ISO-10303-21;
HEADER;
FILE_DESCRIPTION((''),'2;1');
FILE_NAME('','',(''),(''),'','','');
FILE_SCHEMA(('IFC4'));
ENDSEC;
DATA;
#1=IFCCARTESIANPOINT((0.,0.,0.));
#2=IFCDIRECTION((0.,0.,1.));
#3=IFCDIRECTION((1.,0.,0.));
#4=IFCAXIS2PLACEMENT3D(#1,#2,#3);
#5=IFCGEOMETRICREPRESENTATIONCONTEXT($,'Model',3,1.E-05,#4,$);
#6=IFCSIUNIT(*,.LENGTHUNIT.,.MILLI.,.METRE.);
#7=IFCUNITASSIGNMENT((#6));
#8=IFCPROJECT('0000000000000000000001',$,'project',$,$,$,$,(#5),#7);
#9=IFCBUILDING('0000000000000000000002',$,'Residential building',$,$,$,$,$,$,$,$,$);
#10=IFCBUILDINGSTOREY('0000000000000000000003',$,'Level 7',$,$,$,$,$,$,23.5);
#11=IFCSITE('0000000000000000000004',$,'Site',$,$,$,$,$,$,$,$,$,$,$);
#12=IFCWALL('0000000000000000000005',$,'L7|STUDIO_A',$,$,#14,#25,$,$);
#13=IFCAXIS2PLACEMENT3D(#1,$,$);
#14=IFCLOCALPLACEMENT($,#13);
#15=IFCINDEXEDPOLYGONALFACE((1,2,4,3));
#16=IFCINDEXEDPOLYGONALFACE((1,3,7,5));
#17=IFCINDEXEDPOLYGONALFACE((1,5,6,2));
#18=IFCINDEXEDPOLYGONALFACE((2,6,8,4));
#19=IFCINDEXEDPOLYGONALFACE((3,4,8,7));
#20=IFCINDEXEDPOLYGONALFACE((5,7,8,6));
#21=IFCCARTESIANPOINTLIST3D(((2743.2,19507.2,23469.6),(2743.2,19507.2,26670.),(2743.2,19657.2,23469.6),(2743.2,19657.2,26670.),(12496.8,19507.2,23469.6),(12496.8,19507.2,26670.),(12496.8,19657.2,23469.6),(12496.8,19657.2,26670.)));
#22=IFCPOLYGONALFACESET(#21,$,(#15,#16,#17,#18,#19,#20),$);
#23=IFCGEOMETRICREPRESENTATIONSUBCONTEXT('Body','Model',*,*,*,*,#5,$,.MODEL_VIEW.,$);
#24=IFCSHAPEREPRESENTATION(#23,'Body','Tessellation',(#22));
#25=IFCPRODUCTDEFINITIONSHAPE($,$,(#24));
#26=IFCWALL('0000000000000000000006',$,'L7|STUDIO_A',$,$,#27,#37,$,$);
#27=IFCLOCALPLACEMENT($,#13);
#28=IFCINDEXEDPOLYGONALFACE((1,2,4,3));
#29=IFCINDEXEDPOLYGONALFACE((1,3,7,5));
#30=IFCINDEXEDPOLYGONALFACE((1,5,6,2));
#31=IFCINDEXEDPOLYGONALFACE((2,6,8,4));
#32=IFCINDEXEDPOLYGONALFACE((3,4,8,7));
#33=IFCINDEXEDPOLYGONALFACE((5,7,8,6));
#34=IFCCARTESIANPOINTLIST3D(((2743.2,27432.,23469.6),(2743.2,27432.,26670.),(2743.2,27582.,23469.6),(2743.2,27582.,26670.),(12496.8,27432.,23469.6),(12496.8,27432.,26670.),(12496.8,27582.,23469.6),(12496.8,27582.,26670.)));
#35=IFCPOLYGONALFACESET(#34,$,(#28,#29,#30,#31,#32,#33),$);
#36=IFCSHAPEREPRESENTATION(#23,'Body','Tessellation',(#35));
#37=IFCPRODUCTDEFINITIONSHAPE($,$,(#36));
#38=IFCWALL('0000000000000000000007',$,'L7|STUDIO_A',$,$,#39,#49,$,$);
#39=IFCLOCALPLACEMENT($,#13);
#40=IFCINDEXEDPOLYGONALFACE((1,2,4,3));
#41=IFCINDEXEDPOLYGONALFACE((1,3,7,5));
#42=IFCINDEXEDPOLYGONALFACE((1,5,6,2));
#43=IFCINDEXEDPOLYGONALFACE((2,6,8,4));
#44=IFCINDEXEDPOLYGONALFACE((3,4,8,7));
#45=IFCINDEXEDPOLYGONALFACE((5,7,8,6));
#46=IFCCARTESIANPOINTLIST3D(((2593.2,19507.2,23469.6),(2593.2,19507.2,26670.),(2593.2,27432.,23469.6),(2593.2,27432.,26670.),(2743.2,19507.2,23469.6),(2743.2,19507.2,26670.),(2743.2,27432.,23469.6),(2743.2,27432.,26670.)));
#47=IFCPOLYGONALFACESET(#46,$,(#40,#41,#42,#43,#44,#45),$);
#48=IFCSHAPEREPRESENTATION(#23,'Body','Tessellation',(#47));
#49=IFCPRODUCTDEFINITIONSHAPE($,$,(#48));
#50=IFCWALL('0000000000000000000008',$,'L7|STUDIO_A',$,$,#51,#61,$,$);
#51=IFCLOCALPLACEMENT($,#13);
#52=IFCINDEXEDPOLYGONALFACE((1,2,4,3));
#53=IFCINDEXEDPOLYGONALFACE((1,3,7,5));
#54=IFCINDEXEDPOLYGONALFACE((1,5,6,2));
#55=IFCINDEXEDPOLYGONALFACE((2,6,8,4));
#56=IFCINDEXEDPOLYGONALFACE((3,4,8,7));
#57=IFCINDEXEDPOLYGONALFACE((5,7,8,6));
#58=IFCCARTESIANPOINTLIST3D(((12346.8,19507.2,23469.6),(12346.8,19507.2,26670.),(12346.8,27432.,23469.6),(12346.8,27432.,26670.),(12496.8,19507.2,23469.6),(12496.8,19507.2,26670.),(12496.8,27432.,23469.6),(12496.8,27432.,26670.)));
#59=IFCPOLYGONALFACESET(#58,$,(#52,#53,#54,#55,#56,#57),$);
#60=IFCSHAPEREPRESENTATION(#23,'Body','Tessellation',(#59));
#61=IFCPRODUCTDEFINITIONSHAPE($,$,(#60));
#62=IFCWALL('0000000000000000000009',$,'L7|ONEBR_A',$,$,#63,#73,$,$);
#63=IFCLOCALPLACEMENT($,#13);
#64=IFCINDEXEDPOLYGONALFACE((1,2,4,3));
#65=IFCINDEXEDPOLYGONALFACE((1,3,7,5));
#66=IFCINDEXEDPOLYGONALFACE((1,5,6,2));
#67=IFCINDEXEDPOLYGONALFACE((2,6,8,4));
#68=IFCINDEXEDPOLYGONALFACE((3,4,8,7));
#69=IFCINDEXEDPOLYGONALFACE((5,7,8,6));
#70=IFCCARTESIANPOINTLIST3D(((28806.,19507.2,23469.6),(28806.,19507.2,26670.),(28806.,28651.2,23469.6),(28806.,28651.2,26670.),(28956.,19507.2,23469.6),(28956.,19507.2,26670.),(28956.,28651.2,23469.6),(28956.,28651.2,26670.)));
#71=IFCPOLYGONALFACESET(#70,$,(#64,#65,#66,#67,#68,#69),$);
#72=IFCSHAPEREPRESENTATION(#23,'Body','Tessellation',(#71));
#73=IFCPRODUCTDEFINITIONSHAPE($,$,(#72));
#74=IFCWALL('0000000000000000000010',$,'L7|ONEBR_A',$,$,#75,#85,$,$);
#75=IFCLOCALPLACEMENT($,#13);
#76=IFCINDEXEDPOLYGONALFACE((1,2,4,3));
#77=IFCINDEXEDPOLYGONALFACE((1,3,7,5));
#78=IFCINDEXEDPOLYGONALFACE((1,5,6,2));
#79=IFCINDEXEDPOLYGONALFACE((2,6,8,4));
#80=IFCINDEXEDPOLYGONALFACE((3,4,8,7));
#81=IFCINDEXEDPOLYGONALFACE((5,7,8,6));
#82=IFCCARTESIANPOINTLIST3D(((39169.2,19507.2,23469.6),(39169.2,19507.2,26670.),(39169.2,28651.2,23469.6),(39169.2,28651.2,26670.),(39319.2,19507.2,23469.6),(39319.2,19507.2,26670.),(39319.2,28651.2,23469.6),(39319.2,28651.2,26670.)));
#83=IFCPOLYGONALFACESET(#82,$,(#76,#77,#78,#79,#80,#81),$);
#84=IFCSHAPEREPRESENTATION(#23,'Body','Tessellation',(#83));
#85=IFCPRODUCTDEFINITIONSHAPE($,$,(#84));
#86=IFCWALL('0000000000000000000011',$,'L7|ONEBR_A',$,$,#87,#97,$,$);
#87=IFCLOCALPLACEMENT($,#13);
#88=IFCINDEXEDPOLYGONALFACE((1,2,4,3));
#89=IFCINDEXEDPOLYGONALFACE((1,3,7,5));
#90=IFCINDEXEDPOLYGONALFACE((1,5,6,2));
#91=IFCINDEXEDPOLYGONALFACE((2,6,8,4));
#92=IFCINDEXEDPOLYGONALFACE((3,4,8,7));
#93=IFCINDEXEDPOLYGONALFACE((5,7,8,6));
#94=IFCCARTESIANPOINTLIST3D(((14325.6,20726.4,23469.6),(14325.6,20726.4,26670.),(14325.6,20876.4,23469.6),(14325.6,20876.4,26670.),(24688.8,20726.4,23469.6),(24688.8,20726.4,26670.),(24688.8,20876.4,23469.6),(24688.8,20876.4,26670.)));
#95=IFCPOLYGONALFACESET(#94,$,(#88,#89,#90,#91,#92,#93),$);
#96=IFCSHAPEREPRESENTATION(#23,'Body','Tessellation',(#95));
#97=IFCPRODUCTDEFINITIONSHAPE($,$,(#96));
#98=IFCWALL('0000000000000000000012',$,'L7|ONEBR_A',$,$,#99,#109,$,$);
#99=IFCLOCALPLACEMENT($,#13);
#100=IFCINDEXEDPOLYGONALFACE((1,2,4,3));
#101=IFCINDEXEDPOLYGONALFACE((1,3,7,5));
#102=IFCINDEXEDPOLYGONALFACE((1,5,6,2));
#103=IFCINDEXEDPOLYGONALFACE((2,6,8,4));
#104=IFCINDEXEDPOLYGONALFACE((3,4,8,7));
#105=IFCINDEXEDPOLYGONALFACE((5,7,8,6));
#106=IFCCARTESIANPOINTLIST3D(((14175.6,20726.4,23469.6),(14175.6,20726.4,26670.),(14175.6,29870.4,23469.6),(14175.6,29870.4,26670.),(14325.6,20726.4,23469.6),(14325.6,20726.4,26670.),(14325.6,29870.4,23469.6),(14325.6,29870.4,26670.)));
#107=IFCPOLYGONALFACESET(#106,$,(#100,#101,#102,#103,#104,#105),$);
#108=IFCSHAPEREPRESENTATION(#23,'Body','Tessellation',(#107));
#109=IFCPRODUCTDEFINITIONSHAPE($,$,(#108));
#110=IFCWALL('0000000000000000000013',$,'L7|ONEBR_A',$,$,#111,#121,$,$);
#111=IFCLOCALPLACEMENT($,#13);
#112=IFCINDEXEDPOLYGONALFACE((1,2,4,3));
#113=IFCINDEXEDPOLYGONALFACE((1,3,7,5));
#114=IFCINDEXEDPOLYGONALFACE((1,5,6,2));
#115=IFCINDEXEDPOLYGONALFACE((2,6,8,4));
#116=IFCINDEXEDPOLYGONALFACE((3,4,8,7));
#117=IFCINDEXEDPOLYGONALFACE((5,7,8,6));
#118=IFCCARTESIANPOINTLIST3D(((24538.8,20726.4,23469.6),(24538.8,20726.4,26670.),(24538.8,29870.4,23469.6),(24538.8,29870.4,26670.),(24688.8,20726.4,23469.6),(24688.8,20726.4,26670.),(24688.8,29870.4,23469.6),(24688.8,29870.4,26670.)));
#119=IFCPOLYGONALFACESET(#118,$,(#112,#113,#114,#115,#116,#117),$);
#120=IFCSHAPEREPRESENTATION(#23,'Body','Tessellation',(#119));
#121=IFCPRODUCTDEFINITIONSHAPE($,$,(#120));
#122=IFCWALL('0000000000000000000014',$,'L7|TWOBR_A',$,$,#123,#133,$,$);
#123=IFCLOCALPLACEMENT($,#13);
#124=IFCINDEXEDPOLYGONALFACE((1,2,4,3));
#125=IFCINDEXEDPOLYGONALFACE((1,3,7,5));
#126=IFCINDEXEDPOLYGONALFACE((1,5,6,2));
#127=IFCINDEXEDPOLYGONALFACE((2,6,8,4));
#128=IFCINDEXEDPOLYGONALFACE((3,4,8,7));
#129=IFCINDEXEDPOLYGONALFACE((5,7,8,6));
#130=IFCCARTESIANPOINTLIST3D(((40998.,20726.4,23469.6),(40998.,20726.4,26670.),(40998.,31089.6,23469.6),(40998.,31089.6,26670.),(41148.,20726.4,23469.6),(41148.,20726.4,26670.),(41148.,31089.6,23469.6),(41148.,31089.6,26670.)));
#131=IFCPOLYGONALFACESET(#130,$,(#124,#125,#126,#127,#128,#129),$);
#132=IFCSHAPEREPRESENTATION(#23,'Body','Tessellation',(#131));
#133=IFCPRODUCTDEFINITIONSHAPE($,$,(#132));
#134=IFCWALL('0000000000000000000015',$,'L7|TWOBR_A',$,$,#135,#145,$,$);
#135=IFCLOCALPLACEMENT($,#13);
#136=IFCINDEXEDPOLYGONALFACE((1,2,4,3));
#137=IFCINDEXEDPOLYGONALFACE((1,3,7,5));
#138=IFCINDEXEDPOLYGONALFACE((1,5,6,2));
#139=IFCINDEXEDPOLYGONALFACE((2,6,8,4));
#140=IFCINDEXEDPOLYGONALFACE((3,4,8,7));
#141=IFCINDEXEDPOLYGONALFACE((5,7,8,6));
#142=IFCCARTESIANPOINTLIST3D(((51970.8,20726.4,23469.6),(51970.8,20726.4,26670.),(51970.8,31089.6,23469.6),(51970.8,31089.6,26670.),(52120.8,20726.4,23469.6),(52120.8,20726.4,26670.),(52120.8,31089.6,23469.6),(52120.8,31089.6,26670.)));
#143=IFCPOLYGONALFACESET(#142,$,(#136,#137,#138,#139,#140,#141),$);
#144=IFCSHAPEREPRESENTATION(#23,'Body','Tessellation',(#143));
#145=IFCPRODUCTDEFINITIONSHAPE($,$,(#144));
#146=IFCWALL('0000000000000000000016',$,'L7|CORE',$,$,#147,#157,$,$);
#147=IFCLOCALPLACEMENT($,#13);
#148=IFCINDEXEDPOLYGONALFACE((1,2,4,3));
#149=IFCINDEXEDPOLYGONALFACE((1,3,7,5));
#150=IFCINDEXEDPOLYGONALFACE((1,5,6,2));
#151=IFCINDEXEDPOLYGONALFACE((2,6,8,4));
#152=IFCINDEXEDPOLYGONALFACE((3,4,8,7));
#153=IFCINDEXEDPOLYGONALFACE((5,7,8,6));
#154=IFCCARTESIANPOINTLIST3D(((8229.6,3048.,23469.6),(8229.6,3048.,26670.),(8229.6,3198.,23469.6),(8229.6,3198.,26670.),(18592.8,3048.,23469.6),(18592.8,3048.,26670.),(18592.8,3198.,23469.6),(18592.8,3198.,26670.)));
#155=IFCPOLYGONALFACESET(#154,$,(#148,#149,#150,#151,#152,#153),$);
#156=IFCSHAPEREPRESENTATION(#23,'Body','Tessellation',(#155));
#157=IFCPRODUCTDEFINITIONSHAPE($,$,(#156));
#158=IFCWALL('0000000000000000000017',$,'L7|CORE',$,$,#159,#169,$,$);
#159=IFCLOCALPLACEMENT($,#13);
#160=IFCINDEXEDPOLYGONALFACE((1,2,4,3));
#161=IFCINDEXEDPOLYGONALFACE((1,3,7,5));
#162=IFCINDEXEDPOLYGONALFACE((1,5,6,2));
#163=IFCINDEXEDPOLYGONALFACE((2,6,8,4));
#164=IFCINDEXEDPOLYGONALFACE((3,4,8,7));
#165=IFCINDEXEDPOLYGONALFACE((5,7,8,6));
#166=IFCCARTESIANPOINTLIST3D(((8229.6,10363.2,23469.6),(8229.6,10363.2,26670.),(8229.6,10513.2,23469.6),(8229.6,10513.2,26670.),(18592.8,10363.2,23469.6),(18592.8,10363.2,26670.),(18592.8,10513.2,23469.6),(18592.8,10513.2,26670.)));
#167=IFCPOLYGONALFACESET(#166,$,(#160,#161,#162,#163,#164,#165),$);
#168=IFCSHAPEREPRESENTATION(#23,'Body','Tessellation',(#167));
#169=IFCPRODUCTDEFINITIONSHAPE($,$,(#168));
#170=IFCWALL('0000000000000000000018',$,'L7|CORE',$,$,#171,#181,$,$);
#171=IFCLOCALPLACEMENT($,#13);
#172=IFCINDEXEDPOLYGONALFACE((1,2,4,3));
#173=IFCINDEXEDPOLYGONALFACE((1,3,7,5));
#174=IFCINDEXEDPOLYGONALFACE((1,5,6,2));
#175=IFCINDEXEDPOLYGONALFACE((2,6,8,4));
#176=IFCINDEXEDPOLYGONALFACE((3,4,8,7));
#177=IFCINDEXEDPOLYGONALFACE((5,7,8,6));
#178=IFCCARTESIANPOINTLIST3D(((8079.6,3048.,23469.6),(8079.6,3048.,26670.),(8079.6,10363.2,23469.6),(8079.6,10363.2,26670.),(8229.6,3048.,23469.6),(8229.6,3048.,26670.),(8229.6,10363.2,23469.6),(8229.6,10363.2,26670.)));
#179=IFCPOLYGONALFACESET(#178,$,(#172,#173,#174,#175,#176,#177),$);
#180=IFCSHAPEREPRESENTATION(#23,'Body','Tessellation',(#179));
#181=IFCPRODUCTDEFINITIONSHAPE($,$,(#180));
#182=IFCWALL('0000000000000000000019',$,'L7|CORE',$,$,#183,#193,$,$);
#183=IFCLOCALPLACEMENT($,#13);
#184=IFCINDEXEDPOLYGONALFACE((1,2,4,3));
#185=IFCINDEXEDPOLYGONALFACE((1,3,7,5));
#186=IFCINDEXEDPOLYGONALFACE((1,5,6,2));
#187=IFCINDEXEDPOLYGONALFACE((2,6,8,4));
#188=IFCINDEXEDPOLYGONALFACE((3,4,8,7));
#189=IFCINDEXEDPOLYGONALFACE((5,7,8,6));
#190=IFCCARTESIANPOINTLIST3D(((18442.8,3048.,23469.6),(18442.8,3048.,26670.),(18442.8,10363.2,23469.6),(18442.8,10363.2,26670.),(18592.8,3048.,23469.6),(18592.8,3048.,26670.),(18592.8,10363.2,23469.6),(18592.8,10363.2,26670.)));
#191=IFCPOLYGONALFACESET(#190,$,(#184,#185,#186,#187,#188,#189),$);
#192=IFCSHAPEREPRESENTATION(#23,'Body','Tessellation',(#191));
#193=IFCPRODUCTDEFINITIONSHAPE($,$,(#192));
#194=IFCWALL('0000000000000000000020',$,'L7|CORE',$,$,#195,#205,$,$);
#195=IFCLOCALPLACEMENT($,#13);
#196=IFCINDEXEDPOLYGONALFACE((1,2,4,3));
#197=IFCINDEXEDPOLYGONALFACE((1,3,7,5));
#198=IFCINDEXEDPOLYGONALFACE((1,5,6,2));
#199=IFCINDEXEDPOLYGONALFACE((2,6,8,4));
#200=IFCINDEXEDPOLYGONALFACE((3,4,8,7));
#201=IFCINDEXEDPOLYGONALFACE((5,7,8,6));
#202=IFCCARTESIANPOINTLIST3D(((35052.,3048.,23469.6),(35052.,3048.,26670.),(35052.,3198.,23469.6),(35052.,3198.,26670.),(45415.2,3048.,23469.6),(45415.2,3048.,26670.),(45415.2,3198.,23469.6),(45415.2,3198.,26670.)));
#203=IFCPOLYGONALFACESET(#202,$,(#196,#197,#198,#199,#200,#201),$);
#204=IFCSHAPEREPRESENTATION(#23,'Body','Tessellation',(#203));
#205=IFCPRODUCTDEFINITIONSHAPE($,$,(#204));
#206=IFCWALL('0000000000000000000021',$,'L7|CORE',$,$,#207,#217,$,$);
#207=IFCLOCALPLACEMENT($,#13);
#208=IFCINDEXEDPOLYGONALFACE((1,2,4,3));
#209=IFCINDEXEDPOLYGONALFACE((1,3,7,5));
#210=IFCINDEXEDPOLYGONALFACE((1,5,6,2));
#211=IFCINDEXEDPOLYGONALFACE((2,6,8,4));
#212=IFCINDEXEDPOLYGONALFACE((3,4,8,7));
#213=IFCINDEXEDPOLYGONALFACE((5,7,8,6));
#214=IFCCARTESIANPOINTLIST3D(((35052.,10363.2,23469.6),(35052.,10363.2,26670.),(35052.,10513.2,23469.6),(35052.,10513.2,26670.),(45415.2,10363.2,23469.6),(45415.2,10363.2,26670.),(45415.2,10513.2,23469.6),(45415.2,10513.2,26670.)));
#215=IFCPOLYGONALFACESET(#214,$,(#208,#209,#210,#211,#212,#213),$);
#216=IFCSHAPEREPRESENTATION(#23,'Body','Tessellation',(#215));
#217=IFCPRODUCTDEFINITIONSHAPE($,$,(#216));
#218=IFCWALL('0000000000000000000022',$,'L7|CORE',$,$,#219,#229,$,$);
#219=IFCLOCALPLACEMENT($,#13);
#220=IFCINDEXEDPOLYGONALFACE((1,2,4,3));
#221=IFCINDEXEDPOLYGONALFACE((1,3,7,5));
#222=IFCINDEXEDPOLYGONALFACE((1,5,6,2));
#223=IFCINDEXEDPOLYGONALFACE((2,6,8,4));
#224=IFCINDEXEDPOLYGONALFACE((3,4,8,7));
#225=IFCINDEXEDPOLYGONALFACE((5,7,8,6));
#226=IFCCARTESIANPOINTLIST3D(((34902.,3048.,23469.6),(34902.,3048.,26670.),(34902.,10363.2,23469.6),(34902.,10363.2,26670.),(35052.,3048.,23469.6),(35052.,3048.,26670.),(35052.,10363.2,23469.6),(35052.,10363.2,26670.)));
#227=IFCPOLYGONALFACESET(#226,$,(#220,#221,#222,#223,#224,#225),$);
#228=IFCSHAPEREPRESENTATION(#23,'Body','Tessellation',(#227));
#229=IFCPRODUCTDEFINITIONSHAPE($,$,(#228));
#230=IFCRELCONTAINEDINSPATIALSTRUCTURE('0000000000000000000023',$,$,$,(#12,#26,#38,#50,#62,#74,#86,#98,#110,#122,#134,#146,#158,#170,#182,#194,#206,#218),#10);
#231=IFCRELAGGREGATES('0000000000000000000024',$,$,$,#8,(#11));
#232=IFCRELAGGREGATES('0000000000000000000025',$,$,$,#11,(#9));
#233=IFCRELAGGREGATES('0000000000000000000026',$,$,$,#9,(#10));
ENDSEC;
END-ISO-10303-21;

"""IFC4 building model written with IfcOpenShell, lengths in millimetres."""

from ifc_helpers import new_model, si_unit, frame, origin_with_axes, place, context, subcontext, project, spatial, indexed_curve, outline, extrude, element, save


model = new_model("IFC4")

# Units and contexts
model_context = context("Model", 3, precision=1e-05, world=origin_with_axes())
body_context = subcontext(model_context, "Body", "Model", "MODEL_VIEW")
ifc_project = project(units=[si_unit("LENGTHUNIT", "METRE", prefix="MILLI")], contexts=[model_context])

# Site, building, storey
site = spatial("IfcSite", under=ifc_project, Name="Site")
building = spatial("IfcBuilding", under=site, Name="Residential building")
storey = spatial("IfcBuildingStorey", under=building, Name="Level 7", Elevation=23.5)

# Walls
for number, where, z_axis, x_axis, name in (
    (1, (2743.2, 19507.2, 23469.6), (0.0, 0.0, 1.0), (1.0, 0.0, 0.0), "L7|STUDIO_A"),
    (2, (2743.2, 27432.0, 23469.6), (0.0, 0.0, 1.0), (1.0, 0.0, 0.0), "L7|STUDIO_A"),
):
    element("IfcWall", number, at=place(None, frame(where, z_axis=z_axis, x_axis=x_axis)), inside=storey, Name=name, context=body_context, shape_type="SweptSolid", body=[
        extrude(outline(indexed_curve([(0.0, 0.0), (0.0, 150.0), (9753.6, 150.0), (9753.6, 0.0), (0.0, 0.0)], self_intersect=False)), origin_with_axes(), (0.0, 0.0, 1.0), 3200.4),
    ])
for number, where, z_axis, x_axis, name in (
    (3, (2743.2, 19507.2, 23469.6), (0.0, 0.0, 1.0), (0.0, 1.0, 0.0), "L7|STUDIO_A"),
    (4, (12496.8, 19507.2, 23469.6), (0.0, 0.0, 1.0), (0.0, 1.0, 0.0), "L7|STUDIO_A"),
):
    element("IfcWall", number, at=place(None, frame(where, z_axis=z_axis, x_axis=x_axis)), inside=storey, Name=name, context=body_context, shape_type="SweptSolid", body=[
        extrude(outline(indexed_curve([(0.0, 0.0), (0.0, 150.0), (7924.8, 150.0), (7924.8, 0.0), (0.0, 0.0)], self_intersect=False)), origin_with_axes(), (0.0, 0.0, 1.0), 3200.4),
    ])
for number, where, z_axis, x_axis, name in (
    (5, (28956.0, 19507.2, 23469.6), (0.0, 0.0, 1.0), (0.0, 1.0, 0.0), "L7|ONEBR_A"),
    (6, (39319.2, 19507.2, 23469.6), (0.0, 0.0, 1.0), (0.0, 1.0, 0.0), "L7|ONEBR_A"),
):
    element("IfcWall", number, at=place(None, frame(where, z_axis=z_axis, x_axis=x_axis)), inside=storey, Name=name, context=body_context, shape_type="SweptSolid", body=[
        extrude(outline(indexed_curve([(0.0, 0.0), (0.0, 150.0), (9144.0, 150.0), (9144.0, 0.0), (0.0, 0.0)], self_intersect=False)), origin_with_axes(), (0.0, 0.0, 1.0), 3200.4),
    ])
wall_1_placement = place(None, frame((14325.6, 20726.4, 23469.6), z_axis=(0.0, 0.0, 1.0), x_axis=(1.0, 0.0, 0.0)))
element("IfcWall", 7, at=wall_1_placement, inside=storey, Name="L7|ONEBR_A", context=body_context, shape_type="SweptSolid", body=[
    extrude(outline(indexed_curve([(0.0, 0.0), (0.0, 150.0), (10363.2, 150.0), (10363.2, 0.0), (0.0, 0.0)], self_intersect=False)), origin_with_axes(), (0.0, 0.0, 1.0), 3200.4),
])
for number, where, z_axis, x_axis, name in (
    (8, (14325.6, 20726.4, 23469.6), (0.0, 0.0, 1.0), (0.0, 1.0, 0.0), "L7|ONEBR_A"),
    (9, (24688.8, 20726.4, 23469.6), (0.0, 0.0, 1.0), (0.0, 1.0, 0.0), "L7|ONEBR_A"),
):
    element("IfcWall", number, at=place(None, frame(where, z_axis=z_axis, x_axis=x_axis)), inside=storey, Name=name, context=body_context, shape_type="SweptSolid", body=[
        extrude(outline(indexed_curve([(0.0, 0.0), (0.0, 150.0), (9144.0, 150.0), (9144.0, 0.0), (0.0, 0.0)], self_intersect=False)), origin_with_axes(), (0.0, 0.0, 1.0), 3200.4),
    ])
for number, where, z_axis, x_axis, name in (
    (10, (41148.0, 20726.4, 23469.6), (0.0, 0.0, 1.0), (0.0, 1.0, 0.0), "L7|TWOBR_A"),
    (11, (52120.8, 20726.4, 23469.6), (0.0, 0.0, 1.0), (0.0, 1.0, 0.0), "L7|TWOBR_A"),
    (12, (8229.6, 3048.0, 23469.6), (0.0, 0.0, 1.0), (1.0, 0.0, 0.0), "L7|CORE"),
    (13, (8229.6, 10363.2, 23469.6), (0.0, 0.0, 1.0), (1.0, 0.0, 0.0), "L7|CORE"),
):
    element("IfcWall", number, at=place(None, frame(where, z_axis=z_axis, x_axis=x_axis)), inside=storey, Name=name, context=body_context, shape_type="SweptSolid", body=[
        extrude(outline(indexed_curve([(0.0, 0.0), (0.0, 150.0), (10363.2, 150.0), (10363.2, 0.0), (0.0, 0.0)], self_intersect=False)), origin_with_axes(), (0.0, 0.0, 1.0), 3200.4),
    ])
for number, where, z_axis, x_axis, name in (
    (14, (8229.6, 3048.0, 23469.6), (0.0, 0.0, 1.0), (0.0, 1.0, 0.0), "L7|CORE"),
    (15, (18592.8, 3048.0, 23469.6), (0.0, 0.0, 1.0), (0.0, 1.0, 0.0), "L7|CORE"),
):
    element("IfcWall", number, at=place(None, frame(where, z_axis=z_axis, x_axis=x_axis)), inside=storey, Name=name, context=body_context, shape_type="SweptSolid", body=[
        extrude(outline(indexed_curve([(0.0, 0.0), (0.0, 150.0), (7315.2, 150.0), (7315.2, 0.0), (0.0, 0.0)], self_intersect=False)), origin_with_axes(), (0.0, 0.0, 1.0), 3200.4),
    ])
for number, where, z_axis, x_axis, name in (
    (16, (35052.0, 3048.0, 23469.6), (0.0, 0.0, 1.0), (1.0, 0.0, 0.0), "L7|CORE"),
    (17, (35052.0, 10363.2, 23469.6), (0.0, 0.0, 1.0), (1.0, 0.0, 0.0), "L7|CORE"),
):
    element("IfcWall", number, at=place(None, frame(where, z_axis=z_axis, x_axis=x_axis)), inside=storey, Name=name, context=body_context, shape_type="SweptSolid", body=[
        extrude(outline(indexed_curve([(0.0, 0.0), (0.0, 150.0), (10363.2, 150.0), (10363.2, 0.0), (0.0, 0.0)], self_intersect=False)), origin_with_axes(), (0.0, 0.0, 1.0), 3200.4),
    ])
for number, where, z_axis, x_axis, name in (
    (18, (35052.0, 3048.0, 23469.6), (0.0, 0.0, 1.0), (0.0, 1.0, 0.0), "L7|CORE"),
):
    element("IfcWall", number, at=place(None, frame(where, z_axis=z_axis, x_axis=x_axis)), inside=storey, Name=name, context=body_context, shape_type="SweptSolid", body=[
        extrude(outline(indexed_curve([(0.0, 0.0), (0.0, 150.0), (7315.2, 150.0), (7315.2, 0.0), (0.0, 0.0)], self_intersect=False)), origin_with_axes(), (0.0, 0.0, 1.0), 3200.4),
    ])

save(model, "model.ifc")
